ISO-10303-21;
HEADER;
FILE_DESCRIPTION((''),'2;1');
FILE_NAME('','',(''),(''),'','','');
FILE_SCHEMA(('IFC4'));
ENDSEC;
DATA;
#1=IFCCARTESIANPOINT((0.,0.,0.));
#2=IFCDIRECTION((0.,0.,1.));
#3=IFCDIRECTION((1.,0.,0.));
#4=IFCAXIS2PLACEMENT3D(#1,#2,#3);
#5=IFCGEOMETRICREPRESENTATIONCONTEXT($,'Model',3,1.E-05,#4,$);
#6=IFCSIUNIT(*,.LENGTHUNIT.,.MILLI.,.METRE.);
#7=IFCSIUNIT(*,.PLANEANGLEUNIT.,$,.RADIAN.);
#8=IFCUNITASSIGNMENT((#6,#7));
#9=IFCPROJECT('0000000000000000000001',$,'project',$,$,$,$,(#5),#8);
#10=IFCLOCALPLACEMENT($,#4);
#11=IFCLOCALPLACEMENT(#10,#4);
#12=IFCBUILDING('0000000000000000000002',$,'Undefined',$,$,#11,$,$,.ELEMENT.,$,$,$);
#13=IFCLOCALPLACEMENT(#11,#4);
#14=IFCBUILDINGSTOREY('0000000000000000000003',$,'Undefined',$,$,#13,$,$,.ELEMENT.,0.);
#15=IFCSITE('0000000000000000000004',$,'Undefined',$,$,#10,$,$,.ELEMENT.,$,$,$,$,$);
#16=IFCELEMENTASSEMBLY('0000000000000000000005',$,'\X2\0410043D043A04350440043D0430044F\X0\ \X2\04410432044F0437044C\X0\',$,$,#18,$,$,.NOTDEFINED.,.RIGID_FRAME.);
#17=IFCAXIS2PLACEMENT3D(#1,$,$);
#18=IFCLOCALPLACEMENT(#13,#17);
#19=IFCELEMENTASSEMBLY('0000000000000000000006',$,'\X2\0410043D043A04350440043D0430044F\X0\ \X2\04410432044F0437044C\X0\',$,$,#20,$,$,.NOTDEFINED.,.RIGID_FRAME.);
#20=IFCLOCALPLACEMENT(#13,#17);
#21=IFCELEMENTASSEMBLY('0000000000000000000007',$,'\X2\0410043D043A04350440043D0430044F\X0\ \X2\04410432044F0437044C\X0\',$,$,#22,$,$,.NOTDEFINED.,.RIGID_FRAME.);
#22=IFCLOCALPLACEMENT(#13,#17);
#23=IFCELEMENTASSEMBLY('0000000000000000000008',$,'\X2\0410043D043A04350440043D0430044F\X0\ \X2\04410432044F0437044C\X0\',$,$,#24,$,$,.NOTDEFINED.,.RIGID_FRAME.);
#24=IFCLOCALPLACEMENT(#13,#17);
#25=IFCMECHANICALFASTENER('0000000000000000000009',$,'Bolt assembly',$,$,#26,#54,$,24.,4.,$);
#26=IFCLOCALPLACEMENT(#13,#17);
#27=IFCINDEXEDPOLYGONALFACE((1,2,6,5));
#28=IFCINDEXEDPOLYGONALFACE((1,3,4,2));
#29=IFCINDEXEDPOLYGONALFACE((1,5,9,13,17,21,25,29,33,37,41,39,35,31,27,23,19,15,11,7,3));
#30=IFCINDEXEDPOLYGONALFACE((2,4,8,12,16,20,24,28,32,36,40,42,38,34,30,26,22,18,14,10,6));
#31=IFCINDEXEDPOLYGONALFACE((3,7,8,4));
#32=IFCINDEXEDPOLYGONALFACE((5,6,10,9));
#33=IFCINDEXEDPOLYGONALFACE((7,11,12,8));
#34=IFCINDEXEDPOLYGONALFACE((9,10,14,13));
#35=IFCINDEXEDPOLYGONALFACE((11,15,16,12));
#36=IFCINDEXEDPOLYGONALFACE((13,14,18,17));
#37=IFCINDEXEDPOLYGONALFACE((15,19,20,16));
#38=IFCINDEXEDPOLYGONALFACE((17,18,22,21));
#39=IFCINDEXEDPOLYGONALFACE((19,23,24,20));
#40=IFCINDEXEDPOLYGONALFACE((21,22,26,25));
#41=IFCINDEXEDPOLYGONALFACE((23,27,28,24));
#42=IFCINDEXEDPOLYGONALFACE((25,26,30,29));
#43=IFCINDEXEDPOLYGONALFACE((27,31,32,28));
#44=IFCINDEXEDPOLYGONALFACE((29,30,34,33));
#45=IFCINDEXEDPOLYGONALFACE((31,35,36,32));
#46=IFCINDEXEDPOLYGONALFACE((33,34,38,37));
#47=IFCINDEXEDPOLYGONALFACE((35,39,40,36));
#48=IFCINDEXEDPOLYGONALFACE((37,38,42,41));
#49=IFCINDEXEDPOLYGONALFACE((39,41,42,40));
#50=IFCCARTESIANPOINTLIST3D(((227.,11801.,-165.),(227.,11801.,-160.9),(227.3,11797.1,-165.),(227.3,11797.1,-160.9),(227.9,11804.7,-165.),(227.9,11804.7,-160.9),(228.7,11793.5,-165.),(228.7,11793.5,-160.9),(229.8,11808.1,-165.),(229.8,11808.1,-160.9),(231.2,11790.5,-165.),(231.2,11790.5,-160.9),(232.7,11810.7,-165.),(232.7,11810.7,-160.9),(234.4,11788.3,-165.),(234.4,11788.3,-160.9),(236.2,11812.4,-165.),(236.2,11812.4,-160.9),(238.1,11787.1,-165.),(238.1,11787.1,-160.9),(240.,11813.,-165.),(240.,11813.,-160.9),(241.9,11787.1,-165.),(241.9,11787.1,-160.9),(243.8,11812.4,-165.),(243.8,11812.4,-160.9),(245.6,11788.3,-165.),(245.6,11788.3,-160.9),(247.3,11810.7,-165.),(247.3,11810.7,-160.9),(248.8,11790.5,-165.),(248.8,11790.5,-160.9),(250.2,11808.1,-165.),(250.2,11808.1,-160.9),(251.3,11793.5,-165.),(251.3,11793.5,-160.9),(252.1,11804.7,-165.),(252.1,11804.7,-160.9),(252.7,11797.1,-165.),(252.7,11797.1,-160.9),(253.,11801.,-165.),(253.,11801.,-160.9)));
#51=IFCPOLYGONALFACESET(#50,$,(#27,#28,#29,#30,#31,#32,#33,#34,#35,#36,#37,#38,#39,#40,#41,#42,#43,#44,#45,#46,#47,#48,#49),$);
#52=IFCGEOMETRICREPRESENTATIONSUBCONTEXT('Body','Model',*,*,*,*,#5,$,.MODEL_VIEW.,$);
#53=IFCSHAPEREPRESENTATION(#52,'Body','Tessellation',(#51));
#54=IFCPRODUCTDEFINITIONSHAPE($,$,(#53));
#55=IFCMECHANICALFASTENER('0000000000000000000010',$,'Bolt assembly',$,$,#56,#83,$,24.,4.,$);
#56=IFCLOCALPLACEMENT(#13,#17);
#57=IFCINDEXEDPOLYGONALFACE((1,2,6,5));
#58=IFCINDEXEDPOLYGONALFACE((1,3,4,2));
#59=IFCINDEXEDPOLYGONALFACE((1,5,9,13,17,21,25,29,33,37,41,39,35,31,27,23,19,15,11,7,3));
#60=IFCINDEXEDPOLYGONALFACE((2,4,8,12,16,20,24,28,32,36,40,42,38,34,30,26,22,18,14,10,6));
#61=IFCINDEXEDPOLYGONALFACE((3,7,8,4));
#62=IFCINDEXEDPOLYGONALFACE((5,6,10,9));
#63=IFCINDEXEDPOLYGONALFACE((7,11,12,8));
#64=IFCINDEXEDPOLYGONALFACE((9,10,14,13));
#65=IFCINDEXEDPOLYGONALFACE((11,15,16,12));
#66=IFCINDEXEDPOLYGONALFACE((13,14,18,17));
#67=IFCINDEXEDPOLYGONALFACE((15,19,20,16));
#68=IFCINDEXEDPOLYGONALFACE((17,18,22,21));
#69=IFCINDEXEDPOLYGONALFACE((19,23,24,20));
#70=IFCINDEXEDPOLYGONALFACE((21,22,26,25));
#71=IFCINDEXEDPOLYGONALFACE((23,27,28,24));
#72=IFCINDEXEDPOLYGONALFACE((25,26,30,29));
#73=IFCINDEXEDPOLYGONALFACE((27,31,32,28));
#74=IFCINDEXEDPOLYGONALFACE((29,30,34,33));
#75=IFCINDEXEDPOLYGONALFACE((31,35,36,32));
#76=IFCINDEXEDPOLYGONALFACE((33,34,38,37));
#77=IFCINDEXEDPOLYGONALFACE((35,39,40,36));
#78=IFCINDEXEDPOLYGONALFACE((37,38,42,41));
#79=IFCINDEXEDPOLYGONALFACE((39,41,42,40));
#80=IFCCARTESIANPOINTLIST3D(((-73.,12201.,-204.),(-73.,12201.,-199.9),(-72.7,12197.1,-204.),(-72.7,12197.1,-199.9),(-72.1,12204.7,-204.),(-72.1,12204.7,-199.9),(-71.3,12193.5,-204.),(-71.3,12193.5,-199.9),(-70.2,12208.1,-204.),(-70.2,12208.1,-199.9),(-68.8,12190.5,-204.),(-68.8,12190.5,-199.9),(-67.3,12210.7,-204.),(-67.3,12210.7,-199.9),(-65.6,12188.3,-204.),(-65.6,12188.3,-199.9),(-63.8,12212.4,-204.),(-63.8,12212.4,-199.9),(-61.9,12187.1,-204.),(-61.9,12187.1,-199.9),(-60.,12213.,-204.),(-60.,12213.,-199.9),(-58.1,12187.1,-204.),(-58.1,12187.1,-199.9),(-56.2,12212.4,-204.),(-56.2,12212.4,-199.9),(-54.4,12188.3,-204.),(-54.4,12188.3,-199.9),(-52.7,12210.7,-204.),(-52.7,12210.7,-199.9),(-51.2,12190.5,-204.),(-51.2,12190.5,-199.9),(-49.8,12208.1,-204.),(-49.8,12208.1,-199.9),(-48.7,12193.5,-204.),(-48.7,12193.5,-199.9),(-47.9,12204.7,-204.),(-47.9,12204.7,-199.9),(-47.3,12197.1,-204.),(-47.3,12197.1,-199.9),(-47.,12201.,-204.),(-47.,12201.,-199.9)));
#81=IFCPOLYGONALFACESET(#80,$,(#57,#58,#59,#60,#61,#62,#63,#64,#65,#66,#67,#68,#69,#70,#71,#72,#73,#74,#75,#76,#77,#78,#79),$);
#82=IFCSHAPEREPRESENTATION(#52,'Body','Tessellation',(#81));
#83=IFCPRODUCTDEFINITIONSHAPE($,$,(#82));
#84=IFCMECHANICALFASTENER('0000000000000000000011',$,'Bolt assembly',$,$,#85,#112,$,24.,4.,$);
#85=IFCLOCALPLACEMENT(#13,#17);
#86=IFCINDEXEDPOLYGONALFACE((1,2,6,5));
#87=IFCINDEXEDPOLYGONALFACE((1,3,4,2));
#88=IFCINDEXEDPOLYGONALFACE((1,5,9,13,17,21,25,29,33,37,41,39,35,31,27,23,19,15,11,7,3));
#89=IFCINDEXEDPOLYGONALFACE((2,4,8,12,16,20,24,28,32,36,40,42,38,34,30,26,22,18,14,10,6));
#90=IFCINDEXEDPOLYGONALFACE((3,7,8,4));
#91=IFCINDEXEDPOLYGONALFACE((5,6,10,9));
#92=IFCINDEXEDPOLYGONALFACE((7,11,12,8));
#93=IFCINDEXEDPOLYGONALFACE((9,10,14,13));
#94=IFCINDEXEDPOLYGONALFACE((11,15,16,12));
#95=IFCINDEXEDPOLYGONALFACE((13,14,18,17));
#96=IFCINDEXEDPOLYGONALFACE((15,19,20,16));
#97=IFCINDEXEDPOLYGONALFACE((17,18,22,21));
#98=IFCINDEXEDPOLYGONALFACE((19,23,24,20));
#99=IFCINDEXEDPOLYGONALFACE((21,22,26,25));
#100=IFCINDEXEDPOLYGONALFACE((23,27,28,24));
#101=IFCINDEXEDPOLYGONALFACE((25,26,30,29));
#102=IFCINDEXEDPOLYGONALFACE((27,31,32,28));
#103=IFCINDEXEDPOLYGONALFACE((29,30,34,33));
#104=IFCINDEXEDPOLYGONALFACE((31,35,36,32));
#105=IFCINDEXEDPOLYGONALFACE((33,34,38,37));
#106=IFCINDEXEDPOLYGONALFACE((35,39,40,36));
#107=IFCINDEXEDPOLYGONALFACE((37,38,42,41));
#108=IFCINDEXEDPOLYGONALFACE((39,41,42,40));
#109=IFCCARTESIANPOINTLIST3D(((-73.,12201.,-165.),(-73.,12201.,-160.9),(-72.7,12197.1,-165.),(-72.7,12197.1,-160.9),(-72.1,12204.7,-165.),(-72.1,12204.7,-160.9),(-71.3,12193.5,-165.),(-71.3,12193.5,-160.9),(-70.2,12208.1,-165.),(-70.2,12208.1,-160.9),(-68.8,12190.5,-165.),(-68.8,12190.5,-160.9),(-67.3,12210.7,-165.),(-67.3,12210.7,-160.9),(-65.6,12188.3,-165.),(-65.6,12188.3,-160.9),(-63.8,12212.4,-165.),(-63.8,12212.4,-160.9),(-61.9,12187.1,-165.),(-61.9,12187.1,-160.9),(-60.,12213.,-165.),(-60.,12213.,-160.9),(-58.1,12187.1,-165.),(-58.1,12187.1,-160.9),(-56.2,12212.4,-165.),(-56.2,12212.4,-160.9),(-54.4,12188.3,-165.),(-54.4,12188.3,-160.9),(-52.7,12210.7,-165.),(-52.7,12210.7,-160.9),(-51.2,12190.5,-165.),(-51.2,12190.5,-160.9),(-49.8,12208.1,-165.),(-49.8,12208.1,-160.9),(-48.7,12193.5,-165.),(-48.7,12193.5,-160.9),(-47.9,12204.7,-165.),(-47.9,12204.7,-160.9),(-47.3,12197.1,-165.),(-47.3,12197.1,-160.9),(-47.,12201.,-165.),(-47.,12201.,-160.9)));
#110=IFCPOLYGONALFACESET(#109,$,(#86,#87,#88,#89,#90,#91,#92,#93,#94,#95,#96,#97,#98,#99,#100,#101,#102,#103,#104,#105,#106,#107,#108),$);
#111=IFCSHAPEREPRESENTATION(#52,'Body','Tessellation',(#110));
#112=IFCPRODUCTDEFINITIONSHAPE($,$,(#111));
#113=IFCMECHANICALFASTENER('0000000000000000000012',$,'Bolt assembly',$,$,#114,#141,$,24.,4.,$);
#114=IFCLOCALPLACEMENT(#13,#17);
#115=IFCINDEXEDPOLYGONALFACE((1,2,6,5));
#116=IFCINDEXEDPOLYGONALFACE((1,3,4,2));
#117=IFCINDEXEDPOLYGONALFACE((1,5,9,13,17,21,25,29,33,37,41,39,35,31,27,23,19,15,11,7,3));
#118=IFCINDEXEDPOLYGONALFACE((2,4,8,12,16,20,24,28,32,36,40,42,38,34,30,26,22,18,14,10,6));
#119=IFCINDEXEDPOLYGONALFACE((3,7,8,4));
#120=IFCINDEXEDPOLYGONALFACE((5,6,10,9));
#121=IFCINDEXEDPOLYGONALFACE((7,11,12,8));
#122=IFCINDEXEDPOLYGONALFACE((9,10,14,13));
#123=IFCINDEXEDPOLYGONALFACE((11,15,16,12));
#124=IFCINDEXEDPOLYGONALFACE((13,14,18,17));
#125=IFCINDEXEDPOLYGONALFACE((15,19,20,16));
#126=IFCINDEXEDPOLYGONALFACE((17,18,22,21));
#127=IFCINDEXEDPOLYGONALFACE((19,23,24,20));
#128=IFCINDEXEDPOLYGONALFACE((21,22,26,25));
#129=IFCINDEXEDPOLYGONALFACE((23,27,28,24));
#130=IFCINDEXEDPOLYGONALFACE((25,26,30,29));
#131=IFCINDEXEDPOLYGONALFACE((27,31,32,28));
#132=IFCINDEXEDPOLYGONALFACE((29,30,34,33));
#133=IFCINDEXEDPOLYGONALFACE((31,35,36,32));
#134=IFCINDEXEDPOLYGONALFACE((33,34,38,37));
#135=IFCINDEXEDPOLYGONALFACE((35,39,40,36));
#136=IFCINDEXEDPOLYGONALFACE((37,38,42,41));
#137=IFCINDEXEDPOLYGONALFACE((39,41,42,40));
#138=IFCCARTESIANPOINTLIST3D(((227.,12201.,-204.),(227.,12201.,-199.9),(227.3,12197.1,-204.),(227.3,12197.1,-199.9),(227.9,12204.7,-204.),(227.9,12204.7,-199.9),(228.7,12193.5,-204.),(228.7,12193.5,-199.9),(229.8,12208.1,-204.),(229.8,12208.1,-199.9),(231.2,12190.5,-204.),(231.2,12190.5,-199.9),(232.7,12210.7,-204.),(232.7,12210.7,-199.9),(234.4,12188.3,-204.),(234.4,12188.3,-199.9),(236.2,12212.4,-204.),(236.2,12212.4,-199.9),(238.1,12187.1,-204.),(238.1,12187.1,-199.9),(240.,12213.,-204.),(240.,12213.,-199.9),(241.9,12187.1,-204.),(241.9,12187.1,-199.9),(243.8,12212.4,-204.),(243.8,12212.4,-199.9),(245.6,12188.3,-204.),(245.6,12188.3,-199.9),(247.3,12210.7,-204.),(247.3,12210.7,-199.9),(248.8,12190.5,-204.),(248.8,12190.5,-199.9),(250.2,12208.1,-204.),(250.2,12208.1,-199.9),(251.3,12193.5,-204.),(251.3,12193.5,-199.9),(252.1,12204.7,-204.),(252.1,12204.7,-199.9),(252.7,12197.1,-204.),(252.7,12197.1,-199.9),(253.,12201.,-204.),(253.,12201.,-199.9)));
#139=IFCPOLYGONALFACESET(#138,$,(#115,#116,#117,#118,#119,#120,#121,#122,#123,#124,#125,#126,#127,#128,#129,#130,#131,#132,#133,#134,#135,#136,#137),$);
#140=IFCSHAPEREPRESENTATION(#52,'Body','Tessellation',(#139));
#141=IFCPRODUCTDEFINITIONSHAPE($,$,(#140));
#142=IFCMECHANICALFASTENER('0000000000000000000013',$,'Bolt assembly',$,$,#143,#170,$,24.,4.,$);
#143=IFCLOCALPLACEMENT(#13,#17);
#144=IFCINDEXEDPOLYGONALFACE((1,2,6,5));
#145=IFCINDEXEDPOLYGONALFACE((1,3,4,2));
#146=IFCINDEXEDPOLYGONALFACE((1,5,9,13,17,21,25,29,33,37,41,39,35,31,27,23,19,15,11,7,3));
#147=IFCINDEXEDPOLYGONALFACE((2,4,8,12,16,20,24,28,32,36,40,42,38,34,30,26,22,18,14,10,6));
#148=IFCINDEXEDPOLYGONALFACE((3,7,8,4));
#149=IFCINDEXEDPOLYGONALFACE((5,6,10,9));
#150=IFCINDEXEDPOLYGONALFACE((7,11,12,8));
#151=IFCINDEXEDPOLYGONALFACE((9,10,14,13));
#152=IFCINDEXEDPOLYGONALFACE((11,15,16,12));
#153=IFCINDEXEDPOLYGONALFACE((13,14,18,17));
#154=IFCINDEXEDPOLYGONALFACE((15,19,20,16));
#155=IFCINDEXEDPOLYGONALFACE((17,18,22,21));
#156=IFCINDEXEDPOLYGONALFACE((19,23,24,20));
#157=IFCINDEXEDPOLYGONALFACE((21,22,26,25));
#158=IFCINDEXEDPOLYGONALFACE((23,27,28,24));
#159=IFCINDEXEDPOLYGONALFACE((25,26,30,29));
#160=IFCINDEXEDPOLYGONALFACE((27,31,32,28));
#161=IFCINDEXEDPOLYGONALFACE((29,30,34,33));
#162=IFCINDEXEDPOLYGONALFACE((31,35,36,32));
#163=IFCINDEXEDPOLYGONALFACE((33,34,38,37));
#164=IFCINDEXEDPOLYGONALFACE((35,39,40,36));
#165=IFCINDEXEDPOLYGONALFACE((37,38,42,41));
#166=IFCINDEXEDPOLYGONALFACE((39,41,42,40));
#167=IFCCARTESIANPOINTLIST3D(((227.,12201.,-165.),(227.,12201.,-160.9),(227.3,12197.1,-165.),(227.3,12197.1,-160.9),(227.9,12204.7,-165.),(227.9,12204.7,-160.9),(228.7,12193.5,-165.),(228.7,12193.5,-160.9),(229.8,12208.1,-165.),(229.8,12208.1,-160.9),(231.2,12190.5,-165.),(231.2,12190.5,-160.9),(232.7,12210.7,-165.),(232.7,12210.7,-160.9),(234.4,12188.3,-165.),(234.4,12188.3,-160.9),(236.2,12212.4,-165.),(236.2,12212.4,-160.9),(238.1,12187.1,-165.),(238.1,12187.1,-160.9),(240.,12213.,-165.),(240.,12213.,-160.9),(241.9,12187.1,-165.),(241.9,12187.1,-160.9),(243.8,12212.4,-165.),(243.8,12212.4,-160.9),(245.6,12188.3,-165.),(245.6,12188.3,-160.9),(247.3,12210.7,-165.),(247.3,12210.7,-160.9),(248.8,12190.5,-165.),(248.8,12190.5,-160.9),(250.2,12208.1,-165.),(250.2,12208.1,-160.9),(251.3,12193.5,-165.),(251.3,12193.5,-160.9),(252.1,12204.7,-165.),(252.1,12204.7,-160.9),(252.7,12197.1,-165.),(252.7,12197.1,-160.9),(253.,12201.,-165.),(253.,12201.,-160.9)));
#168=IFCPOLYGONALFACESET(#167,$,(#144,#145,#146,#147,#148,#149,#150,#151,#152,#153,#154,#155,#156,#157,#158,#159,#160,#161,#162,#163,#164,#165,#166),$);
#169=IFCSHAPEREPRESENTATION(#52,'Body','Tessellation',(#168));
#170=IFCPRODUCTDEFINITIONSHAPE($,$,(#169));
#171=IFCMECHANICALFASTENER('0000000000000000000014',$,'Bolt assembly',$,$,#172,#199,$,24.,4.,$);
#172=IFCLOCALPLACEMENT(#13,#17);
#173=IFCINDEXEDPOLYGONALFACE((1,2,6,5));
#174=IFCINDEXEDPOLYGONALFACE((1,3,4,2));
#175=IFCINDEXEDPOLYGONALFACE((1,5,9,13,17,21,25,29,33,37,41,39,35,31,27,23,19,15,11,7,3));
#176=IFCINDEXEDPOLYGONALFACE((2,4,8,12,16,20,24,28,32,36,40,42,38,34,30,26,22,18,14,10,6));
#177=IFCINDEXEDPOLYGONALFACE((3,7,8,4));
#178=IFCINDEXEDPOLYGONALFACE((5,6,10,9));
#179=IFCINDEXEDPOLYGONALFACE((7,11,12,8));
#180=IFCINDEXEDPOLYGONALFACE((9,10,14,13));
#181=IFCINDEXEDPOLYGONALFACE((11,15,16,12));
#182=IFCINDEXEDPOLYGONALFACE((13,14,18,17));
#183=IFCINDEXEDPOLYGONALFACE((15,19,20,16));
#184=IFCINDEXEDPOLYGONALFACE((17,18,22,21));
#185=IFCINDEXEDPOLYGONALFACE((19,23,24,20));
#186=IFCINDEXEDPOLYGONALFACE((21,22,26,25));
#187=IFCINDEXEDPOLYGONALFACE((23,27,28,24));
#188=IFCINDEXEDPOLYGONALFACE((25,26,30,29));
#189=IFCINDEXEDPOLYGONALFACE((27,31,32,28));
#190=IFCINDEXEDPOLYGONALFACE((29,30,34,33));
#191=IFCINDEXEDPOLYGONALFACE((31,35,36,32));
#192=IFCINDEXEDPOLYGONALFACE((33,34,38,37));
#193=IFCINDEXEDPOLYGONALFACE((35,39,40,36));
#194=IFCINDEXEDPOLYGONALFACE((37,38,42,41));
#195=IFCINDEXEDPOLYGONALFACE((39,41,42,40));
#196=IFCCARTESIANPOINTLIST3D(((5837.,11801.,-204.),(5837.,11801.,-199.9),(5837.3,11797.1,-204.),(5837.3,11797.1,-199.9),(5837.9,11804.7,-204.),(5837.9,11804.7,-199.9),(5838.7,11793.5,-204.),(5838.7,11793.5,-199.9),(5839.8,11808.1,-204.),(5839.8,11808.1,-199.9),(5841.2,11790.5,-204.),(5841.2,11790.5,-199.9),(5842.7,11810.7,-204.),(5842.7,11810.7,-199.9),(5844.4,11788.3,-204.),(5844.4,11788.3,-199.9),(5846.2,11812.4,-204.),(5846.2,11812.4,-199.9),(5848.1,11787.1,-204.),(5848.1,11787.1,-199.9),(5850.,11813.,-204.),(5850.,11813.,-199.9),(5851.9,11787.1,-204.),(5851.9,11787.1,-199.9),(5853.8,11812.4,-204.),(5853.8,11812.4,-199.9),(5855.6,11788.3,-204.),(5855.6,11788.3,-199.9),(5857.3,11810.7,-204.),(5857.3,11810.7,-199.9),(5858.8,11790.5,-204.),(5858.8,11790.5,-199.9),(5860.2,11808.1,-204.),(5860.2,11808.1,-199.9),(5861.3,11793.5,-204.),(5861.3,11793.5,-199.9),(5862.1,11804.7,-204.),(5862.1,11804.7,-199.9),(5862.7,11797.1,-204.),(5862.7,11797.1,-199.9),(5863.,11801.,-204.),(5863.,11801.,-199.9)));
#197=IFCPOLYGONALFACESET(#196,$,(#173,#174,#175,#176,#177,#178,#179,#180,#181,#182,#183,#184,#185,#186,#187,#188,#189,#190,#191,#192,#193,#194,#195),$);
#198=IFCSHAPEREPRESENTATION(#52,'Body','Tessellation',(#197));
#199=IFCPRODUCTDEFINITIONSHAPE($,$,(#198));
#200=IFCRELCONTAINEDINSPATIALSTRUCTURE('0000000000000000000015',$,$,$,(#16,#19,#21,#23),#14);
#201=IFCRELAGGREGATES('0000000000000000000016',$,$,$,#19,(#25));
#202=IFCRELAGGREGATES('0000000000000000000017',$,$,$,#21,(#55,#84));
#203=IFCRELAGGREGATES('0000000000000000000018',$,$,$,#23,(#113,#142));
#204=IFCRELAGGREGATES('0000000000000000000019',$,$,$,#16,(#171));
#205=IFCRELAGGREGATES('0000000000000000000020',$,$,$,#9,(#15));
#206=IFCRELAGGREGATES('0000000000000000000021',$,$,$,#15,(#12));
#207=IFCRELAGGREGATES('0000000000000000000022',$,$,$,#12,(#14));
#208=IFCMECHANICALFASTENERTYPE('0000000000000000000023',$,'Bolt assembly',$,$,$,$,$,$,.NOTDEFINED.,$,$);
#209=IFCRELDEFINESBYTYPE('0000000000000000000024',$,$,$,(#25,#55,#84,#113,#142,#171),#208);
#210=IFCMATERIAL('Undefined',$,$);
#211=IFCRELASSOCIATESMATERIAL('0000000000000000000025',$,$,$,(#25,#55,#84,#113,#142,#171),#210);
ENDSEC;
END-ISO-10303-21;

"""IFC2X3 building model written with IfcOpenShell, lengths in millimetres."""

from ifc_helpers import new_model, si_unit, frame, origin_with_axes, origin_2d_with_axis, place, context, subcontext, project, spatial, circle, extrude, source, transform, mapped, material, type_object, element, aggregate, save


model = new_model("IFC2X3")

# Units and contexts
model_context = context("Model", 3, precision=1e-05, world=origin_with_axes())
body_context = subcontext(model_context, "Body", "Model", "MODEL_VIEW")
ifc_project = project(units=[si_unit("LENGTHUNIT", "METRE", prefix="MILLI"), si_unit("PLANEANGLEUNIT", "RADIAN")], contexts=[model_context])

# Site, building, storey
site_placement = place(None, origin_with_axes())
site = spatial("IfcSite", under=ifc_project, at=site_placement, Name="Undefined", CompositionType="ELEMENT")
building_placement = place(site_placement, origin_with_axes())
building = spatial("IfcBuilding", under=site, at=building_placement, Name="Undefined", CompositionType="ELEMENT")
storey_placement = place(building_placement, origin_with_axes())
storey = spatial("IfcBuildingStorey", under=building, at=storey_placement, Name="Undefined", CompositionType="ELEMENT", Elevation=0.0)

# Element assembly
assembly_1_placement = place(storey_placement, origin_with_axes())
assembly_1 = element("IfcElementAssembly", 1, at=assembly_1_placement, inside=storey, Name="Анкерная связь", AssemblyPlace="NOTDEFINED", PredefinedType="RIGID_FRAME")

# Element assemblies
assembly_2_placement = place(storey_placement, origin_with_axes())
assembly_2 = element("IfcElementAssembly", 2, at=assembly_2_placement, inside=storey, Name="Анкерная связь", AssemblyPlace="NOTDEFINED", PredefinedType="RIGID_FRAME")
assembly_3_placement = place(storey_placement, origin_with_axes())
assembly_3 = element("IfcElementAssembly", 3, at=assembly_3_placement, inside=storey, Name="Анкерная связь", AssemblyPlace="NOTDEFINED", PredefinedType="RIGID_FRAME")
assembly_4_placement = place(storey_placement, origin_with_axes())
assembly_4 = element("IfcElementAssembly", 4, at=assembly_4_placement, inside=storey, Name="Анкерная связь", AssemblyPlace="NOTDEFINED", PredefinedType="RIGID_FRAME")

# Mechanical fasteners
ifc_material_1 = material(Name="Undefined")
mechanical_fastener_type = type_object("IfcMechanicalFastenerType", Name="Bolt assembly")
shared_shape_1 = source(origin_with_axes(), body_context, "Body", "SweptSolid", [
    extrude(circle(Radius=13.0, at=origin_2d_with_axis()), frame((0.0, -4.0, 0.0), z_axis=(0.0, 1.0, 0.0), x_axis=(1.0, 0.0, 0.0)), (0.0, 0.0, 1.0), 4.1),
])
mechanical_fastener_1_placement = place(assembly_2_placement, frame((240.0, 11800.0, -161.0), z_axis=(1.0, 0.0, 0.0), x_axis=(0.0, 1.0, 0.0)))
mechanical_fastener_1 = element("IfcMechanicalFastener", 5, at=mechanical_fastener_1_placement, type_object=mechanical_fastener_type, material=ifc_material_1, Name="Bolt assembly", NominalDiameter=24.0, NominalLength=4.0, context=body_context, shape_type="MappedRepresentation", body=[
    mapped(shared_shape_1, transform((0.0, 0.0, 0.0))),
])
aggregate(assembly_2, [mechanical_fastener_1])
mechanical_fastener_2_placement = place(assembly_3_placement, frame((-60.0, 12200.0, -200.0), z_axis=(1.0, 0.0, 0.0), x_axis=(0.0, 1.0, 0.0)))
mechanical_fastener_2 = element("IfcMechanicalFastener", 6, at=mechanical_fastener_2_placement, type_object=mechanical_fastener_type, material=ifc_material_1, Name="Bolt assembly", NominalDiameter=24.0, NominalLength=4.0, context=body_context, shape_type="MappedRepresentation", body=[
    mapped(shared_shape_1, transform((0.0, 0.0, 0.0))),
])
mechanical_fastener_3_placement = place(assembly_3_placement, frame((-60.0, 12200.0, -161.0), z_axis=(1.0, 0.0, 0.0), x_axis=(0.0, 1.0, 0.0)))
mechanical_fastener_3 = element("IfcMechanicalFastener", 7, at=mechanical_fastener_3_placement, type_object=mechanical_fastener_type, material=ifc_material_1, Name="Bolt assembly", NominalDiameter=24.0, NominalLength=4.0, context=body_context, shape_type="MappedRepresentation", body=[
    mapped(shared_shape_1, transform((0.0, 0.0, 0.0))),
])
aggregate(assembly_3, [mechanical_fastener_2, mechanical_fastener_3])
mechanical_fastener_4_placement = place(assembly_4_placement, frame((240.0, 12200.0, -200.0), z_axis=(1.0, 0.0, 0.0), x_axis=(0.0, 1.0, 0.0)))
mechanical_fastener_4 = element("IfcMechanicalFastener", 8, at=mechanical_fastener_4_placement, type_object=mechanical_fastener_type, material=ifc_material_1, Name="Bolt assembly", NominalDiameter=24.0, NominalLength=4.0, context=body_context, shape_type="MappedRepresentation", body=[
    mapped(shared_shape_1, transform((0.0, 0.0, 0.0))),
])
mechanical_fastener_5_placement = place(assembly_4_placement, frame((240.0, 12200.0, -161.0), z_axis=(1.0, 0.0, 0.0), x_axis=(0.0, 1.0, 0.0)))
mechanical_fastener_5 = element("IfcMechanicalFastener", 9, at=mechanical_fastener_5_placement, type_object=mechanical_fastener_type, material=ifc_material_1, Name="Bolt assembly", NominalDiameter=24.0, NominalLength=4.0, context=body_context, shape_type="MappedRepresentation", body=[
    mapped(shared_shape_1, transform((0.0, 0.0, 0.0))),
])
aggregate(assembly_4, [mechanical_fastener_4, mechanical_fastener_5])
mechanical_fastener_6_placement = place(assembly_1_placement, frame((5850.0, 11800.0, -200.0), z_axis=(1.0, 0.0, 0.0), x_axis=(0.0, 1.0, 0.0)))
mechanical_fastener_6 = element("IfcMechanicalFastener", 10, at=mechanical_fastener_6_placement, type_object=mechanical_fastener_type, material=ifc_material_1, Name="Bolt assembly", NominalDiameter=24.0, NominalLength=4.0, context=body_context, shape_type="MappedRepresentation", body=[
    mapped(shared_shape_1, transform((0.0, 0.0, 0.0))),
])
aggregate(assembly_1, [mechanical_fastener_6])

save(model, "model.ifc")
